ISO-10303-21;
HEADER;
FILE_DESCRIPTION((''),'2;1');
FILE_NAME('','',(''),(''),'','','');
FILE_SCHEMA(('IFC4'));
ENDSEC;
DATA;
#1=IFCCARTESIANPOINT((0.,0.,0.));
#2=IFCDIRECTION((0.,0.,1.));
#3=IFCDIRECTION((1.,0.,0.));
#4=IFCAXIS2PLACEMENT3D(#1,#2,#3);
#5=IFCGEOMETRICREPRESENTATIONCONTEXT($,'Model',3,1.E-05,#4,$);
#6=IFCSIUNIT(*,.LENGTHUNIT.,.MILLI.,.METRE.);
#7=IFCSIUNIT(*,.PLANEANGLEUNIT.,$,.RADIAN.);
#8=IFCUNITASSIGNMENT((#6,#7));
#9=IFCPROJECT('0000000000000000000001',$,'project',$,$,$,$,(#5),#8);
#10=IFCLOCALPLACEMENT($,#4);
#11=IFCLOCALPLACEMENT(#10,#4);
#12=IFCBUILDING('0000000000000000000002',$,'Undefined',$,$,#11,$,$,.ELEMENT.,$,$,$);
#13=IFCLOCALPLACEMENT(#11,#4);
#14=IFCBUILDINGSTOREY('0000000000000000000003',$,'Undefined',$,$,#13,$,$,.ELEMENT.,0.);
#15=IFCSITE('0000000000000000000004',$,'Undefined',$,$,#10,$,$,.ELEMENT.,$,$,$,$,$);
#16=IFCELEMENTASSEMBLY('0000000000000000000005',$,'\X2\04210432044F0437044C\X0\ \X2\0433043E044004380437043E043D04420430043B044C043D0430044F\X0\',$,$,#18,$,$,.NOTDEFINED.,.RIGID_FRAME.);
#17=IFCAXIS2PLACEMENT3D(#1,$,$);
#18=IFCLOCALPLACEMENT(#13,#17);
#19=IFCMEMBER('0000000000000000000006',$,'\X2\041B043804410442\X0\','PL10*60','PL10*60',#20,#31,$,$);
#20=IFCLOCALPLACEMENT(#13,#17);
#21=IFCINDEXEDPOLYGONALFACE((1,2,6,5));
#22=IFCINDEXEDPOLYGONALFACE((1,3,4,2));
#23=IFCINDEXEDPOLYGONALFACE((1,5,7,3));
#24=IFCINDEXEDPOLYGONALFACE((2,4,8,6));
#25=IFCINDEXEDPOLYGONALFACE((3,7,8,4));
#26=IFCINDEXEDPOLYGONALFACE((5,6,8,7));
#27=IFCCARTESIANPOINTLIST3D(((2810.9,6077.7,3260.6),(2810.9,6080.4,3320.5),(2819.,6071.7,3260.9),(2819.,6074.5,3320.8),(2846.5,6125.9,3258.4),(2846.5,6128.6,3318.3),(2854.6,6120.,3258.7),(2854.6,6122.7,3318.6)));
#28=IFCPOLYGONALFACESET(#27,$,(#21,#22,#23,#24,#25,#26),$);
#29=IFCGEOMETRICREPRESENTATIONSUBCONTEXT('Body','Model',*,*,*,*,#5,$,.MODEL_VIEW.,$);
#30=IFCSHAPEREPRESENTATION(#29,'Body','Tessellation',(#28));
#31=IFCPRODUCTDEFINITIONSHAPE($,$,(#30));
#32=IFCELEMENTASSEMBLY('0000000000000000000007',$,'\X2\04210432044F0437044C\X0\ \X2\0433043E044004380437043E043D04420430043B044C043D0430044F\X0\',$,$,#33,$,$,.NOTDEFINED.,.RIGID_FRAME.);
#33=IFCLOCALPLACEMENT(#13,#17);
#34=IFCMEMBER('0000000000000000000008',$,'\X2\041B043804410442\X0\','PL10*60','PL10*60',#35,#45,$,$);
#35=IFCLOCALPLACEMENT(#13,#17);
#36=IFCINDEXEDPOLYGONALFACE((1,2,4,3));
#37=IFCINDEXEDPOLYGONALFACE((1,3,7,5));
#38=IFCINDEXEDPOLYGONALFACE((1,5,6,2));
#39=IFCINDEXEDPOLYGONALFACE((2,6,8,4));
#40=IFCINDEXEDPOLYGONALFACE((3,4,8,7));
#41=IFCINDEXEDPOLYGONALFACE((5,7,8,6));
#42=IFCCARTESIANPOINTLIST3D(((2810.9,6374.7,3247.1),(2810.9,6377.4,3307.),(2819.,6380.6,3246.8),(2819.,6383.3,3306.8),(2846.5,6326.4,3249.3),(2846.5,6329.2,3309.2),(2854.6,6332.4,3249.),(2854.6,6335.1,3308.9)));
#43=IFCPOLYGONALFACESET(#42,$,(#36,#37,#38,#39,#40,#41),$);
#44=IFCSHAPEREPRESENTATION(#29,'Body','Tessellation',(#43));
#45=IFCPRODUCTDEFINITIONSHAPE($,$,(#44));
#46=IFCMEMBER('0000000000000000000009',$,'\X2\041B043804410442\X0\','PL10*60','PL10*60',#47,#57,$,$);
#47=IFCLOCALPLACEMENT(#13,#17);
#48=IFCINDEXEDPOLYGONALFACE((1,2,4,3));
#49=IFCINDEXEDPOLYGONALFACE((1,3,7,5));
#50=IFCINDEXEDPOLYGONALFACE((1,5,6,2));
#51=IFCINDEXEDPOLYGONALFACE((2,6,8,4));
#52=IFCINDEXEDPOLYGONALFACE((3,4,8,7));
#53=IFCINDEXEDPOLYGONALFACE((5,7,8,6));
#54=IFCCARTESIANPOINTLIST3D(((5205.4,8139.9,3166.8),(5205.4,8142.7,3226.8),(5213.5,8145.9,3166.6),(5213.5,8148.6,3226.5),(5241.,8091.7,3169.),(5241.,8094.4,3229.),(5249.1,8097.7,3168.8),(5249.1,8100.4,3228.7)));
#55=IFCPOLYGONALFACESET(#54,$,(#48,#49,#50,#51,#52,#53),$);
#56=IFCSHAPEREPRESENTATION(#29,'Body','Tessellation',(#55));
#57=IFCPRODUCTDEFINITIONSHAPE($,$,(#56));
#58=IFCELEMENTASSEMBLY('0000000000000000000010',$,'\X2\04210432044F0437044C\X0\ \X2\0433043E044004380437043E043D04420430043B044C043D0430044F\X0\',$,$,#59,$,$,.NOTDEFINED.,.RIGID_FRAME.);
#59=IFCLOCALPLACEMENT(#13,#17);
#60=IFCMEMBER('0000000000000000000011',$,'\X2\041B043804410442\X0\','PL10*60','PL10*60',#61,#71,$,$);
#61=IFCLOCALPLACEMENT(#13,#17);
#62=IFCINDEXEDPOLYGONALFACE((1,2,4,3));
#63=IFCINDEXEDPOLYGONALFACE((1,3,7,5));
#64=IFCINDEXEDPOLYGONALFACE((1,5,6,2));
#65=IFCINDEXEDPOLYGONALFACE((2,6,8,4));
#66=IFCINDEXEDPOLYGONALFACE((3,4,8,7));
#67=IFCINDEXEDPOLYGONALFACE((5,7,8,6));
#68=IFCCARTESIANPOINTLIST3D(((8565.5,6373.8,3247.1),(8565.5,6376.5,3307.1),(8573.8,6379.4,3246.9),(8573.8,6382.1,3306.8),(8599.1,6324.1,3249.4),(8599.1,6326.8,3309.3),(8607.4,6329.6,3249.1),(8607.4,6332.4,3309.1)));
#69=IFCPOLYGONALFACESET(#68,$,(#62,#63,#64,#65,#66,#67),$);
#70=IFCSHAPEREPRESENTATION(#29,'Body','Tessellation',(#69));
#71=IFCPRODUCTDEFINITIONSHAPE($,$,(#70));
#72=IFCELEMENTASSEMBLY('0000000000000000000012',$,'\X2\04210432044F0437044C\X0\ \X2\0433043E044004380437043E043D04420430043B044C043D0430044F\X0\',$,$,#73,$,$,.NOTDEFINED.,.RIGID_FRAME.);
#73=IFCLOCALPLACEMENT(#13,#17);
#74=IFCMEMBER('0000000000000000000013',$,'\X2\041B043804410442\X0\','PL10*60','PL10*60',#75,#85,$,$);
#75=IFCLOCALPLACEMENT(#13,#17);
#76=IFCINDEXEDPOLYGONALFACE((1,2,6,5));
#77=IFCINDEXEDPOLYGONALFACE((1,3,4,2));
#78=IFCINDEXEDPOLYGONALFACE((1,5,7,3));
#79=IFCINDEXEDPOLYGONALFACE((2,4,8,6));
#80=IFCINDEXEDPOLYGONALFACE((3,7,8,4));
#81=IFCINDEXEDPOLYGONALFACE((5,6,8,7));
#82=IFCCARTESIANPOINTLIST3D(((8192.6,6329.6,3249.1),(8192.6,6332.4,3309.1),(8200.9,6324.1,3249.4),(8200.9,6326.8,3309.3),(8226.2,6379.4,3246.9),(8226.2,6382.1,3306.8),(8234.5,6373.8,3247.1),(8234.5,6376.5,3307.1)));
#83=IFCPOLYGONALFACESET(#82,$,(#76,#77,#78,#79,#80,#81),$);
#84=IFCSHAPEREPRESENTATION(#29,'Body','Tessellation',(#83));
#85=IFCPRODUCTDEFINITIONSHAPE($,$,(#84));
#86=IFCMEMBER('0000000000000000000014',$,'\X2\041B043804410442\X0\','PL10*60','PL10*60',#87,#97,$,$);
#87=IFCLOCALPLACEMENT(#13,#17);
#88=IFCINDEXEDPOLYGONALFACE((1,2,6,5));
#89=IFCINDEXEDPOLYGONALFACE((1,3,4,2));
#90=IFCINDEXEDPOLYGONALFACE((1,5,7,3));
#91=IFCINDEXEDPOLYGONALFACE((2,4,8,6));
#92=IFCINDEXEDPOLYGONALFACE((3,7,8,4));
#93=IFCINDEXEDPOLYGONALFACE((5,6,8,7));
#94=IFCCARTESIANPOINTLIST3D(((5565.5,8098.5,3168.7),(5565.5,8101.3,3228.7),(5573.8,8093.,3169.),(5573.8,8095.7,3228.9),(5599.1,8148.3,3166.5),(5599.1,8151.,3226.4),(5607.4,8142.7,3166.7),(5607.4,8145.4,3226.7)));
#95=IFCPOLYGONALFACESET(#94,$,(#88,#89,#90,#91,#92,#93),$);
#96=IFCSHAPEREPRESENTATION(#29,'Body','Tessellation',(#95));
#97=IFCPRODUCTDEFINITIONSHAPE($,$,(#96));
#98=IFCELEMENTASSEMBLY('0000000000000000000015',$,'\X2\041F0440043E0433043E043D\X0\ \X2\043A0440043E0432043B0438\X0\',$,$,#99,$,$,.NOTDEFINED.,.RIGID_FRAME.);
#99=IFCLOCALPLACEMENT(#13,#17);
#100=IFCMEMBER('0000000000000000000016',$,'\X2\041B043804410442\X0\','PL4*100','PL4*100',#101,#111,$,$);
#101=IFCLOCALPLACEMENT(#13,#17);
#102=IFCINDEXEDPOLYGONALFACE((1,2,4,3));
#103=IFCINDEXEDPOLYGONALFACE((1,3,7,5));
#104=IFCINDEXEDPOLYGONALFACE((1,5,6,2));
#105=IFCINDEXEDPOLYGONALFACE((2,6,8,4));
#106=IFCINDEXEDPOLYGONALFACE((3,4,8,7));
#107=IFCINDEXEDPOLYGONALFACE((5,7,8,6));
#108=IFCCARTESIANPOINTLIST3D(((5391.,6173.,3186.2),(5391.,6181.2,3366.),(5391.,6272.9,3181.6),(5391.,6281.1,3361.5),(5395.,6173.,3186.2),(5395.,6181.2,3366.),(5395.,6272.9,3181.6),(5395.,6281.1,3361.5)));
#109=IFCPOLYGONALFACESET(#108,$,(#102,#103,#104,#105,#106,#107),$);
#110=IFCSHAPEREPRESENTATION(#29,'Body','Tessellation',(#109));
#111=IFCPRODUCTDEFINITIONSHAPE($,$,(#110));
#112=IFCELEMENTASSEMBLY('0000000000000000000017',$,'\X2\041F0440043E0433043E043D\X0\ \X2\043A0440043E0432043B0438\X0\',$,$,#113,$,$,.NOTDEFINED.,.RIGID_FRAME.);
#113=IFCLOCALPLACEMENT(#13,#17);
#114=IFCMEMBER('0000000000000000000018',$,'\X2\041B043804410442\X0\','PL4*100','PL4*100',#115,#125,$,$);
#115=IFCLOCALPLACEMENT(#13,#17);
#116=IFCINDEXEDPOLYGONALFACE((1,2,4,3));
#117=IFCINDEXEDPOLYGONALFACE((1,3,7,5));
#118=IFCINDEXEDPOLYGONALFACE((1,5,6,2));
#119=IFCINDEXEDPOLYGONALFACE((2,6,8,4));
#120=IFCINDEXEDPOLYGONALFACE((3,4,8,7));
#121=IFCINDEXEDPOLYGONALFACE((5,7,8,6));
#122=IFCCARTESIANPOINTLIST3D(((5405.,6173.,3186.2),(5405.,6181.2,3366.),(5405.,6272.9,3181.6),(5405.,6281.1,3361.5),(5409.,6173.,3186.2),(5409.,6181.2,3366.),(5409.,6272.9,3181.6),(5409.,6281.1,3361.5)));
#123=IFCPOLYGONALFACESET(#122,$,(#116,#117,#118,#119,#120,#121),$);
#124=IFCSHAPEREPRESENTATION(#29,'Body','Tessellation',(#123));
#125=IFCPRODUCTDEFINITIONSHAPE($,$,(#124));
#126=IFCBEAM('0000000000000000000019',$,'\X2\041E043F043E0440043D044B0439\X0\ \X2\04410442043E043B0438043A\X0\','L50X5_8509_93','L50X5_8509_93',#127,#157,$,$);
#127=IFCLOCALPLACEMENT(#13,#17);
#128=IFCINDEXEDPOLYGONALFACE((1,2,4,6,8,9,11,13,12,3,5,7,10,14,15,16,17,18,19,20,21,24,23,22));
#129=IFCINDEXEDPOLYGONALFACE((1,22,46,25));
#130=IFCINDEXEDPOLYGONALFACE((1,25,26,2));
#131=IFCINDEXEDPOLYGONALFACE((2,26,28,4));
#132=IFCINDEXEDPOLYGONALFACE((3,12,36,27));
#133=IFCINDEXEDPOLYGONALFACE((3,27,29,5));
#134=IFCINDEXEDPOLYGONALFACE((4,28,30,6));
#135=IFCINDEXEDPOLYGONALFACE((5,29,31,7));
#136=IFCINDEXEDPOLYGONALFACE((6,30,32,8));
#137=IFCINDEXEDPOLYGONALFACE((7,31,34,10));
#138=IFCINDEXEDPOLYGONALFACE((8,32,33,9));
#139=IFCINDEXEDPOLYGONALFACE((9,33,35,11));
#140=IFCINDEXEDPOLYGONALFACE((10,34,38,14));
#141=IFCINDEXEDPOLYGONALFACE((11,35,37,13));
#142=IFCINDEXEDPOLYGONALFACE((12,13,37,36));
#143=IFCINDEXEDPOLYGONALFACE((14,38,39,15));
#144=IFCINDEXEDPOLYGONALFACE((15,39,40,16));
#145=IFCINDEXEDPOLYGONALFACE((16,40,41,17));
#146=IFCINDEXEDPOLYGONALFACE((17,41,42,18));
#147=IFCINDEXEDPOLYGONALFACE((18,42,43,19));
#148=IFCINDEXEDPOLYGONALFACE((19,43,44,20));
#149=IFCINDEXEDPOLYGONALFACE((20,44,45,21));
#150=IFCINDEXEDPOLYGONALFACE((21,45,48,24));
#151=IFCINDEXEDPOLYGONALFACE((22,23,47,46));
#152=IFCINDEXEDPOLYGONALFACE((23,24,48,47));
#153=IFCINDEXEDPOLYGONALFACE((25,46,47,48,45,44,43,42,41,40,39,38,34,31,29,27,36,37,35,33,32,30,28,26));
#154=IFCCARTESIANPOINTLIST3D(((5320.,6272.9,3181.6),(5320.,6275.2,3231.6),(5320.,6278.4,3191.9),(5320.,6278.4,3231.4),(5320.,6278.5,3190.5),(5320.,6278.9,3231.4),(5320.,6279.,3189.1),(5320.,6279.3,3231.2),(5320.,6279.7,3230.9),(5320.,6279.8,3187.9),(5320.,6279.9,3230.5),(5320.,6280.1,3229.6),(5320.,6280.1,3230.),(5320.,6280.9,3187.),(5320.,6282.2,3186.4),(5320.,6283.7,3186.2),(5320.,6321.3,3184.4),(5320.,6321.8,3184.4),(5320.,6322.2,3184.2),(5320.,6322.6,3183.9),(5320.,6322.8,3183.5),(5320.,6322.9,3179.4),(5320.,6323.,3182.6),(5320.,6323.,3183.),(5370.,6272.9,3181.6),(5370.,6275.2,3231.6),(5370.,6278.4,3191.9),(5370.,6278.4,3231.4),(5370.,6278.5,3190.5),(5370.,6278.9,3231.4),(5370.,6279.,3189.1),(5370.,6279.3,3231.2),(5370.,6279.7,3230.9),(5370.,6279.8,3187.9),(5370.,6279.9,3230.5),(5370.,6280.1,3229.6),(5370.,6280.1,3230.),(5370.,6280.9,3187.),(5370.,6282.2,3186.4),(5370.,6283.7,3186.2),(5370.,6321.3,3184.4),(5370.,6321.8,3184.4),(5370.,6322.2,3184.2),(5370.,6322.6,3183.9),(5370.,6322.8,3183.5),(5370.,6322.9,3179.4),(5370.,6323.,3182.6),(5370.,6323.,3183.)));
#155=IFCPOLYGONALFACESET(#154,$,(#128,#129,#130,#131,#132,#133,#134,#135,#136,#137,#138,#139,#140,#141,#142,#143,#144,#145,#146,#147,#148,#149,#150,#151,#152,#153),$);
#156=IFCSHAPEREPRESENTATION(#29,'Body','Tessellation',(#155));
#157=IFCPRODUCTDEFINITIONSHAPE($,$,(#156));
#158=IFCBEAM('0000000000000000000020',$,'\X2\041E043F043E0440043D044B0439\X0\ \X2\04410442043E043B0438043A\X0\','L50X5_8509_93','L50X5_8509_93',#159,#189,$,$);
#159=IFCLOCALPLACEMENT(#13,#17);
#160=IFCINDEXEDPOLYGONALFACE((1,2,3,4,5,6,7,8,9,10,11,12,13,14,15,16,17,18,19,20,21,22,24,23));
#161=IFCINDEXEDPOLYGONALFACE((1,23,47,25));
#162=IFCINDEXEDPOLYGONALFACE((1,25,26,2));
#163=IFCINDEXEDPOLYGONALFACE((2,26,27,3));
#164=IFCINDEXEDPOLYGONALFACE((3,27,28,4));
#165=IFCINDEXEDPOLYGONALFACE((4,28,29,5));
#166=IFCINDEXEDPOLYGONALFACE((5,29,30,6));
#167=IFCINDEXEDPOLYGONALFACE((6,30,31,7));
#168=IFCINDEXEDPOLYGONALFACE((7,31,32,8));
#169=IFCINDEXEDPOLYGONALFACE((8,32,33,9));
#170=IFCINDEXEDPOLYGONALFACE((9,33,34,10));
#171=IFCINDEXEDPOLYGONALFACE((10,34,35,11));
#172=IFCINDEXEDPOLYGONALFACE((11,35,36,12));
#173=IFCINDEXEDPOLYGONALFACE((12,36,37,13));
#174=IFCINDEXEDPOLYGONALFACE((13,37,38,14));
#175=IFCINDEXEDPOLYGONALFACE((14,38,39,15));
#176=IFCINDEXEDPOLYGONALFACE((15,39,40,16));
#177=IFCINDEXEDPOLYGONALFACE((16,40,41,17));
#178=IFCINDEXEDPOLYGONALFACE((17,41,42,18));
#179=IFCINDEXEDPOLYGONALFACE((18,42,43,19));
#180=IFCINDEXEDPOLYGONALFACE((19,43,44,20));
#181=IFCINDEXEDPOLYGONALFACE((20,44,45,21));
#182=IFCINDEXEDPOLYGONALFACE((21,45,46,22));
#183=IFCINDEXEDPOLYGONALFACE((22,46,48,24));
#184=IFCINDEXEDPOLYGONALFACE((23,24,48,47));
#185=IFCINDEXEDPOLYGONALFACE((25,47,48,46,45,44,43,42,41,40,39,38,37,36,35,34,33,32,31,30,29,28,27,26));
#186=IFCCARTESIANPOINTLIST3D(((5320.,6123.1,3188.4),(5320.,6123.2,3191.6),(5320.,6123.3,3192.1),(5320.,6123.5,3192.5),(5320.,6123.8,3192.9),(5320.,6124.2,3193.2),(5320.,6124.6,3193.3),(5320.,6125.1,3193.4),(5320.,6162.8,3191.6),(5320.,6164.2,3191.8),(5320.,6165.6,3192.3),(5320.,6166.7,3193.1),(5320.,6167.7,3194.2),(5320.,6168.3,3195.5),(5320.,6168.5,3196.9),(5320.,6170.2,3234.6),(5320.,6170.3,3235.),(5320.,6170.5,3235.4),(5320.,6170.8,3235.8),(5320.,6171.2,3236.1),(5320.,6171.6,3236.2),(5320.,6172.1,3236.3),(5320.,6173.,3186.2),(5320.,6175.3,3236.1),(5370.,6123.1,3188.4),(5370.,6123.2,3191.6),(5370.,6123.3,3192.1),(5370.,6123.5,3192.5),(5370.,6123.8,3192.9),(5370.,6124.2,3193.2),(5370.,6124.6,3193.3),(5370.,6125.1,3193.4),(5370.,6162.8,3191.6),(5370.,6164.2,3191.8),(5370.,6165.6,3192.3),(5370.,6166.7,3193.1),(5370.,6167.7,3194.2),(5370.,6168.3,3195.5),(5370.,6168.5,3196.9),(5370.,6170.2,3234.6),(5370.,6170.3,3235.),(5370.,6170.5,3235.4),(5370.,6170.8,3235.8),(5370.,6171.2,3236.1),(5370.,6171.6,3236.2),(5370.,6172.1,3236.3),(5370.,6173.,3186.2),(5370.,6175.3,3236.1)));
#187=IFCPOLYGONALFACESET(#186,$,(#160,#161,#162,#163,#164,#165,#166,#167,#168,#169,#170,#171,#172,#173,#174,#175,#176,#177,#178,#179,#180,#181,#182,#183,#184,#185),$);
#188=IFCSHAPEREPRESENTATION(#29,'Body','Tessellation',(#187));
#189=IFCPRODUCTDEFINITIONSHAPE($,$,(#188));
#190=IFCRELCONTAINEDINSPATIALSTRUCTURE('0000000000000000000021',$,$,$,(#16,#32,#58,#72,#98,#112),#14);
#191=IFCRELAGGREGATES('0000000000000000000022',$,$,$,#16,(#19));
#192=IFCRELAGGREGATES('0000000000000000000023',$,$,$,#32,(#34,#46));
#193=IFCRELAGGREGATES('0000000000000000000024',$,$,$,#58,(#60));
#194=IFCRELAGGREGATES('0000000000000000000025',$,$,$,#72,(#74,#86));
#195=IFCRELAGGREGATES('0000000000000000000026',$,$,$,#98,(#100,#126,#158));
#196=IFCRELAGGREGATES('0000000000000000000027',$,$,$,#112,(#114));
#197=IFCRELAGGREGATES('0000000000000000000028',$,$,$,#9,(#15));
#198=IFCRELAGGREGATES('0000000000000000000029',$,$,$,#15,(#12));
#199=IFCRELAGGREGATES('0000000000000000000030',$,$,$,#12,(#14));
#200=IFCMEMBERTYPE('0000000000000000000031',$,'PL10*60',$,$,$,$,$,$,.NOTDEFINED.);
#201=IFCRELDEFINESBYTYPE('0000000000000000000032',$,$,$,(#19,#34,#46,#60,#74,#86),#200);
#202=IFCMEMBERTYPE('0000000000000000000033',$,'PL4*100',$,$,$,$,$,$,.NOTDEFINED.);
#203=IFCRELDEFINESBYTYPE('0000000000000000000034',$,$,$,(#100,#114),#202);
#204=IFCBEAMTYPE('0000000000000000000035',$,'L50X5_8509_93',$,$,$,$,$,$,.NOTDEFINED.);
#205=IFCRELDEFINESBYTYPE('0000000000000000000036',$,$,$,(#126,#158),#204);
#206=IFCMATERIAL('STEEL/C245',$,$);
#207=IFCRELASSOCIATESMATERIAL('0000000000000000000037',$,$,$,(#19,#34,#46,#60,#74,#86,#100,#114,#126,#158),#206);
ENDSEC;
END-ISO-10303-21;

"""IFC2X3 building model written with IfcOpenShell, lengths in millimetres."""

from ifc_helpers import new_model, si_unit, frame, origin_with_axes, origin_2d_with_axis, place, context, subcontext, project, spatial, rectangle, l_section, extrude, material, type_object, element, aggregate, save


model = new_model("IFC2X3")

# Units and contexts
model_context = context("Model", 3, precision=1e-05, world=origin_with_axes())
body_context = subcontext(model_context, "Body", "Model", "MODEL_VIEW")
ifc_project = project(units=[si_unit("LENGTHUNIT", "METRE", prefix="MILLI"), si_unit("PLANEANGLEUNIT", "RADIAN")], contexts=[model_context])

# Site, building, storey
site_placement = place(None, origin_with_axes())
site = spatial("IfcSite", under=ifc_project, at=site_placement, Name="Undefined", CompositionType="ELEMENT")
building_placement = place(site_placement, origin_with_axes())
building = spatial("IfcBuilding", under=site, at=building_placement, Name="Undefined", CompositionType="ELEMENT")
storey_placement = place(building_placement, origin_with_axes())
storey = spatial("IfcBuildingStorey", under=building, at=storey_placement, Name="Undefined", CompositionType="ELEMENT", Elevation=0.0)

# Element assembly, member
assembly_1_placement = place(storey_placement, origin_with_axes())
assembly_1 = element("IfcElementAssembly", 1, at=assembly_1_placement, inside=storey, Name="Связь горизонтальная", AssemblyPlace="NOTDEFINED", PredefinedType="RIGID_FRAME")
ifc_material_1 = material(Name="STEEL/C245")
member_type_1 = type_object("IfcMemberType", Name="PL10*60", PredefinedType="NOTDEFINED")
member_1_placement = place(assembly_1_placement, frame((2832.7, 6098.8, 3259.6), z_axis=(0.593795, 0.803786, -0.036536), x_axis=(0.0, 0.045408, 0.998969)))
member_1 = element("IfcMember", 2, at=member_1_placement, type_object=member_type_1, material=ifc_material_1, Name="Лист", Description="PL10*60", ObjectType="PL10*60", context=body_context, shape_type="SweptSolid", body=[
    extrude(rectangle(XDim=10.0, YDim=60.0, at=origin_2d_with_axis()), frame((60.0, 0.0, 0.0), z_axis=(-1.0, 0.0, 0.0), x_axis=(0.0, -1.0, 0.0)), (0.0, 0.0, 1.0), 60.0),
])

# Element assembly, members
assembly_2_placement = place(storey_placement, origin_with_axes())
assembly_2 = element("IfcElementAssembly", 3, at=assembly_2_placement, inside=storey, Name="Связь горизонтальная", AssemblyPlace="NOTDEFINED", PredefinedType="RIGID_FRAME")
member_2_placement = place(assembly_2_placement, frame((2832.7, 6353.5, 3248.0), z_axis=(-0.593795, 0.803786, -0.036536), x_axis=(0.0, 0.045408, 0.998969)))
member_2 = element("IfcMember", 4, at=member_2_placement, type_object=member_type_1, material=ifc_material_1, Name="Лист", Description="PL10*60", ObjectType="PL10*60", context=body_context, shape_type="SweptSolid", body=[
    extrude(rectangle(XDim=10.0, YDim=60.0, at=origin_2d_with_axis()), frame((60.0, 0.0, 0.0), z_axis=(-1.0, 0.0, 0.0), x_axis=(0.0, -1.0, 0.0)), (0.0, 0.0, 1.0), 60.0),
])
member_3_placement = place(assembly_2_placement, frame((5227.3, 8118.8, 3167.8), z_axis=(0.593795, -0.803786, 0.036536), x_axis=(0.0, 0.045408, 0.998969)))
member_3 = element("IfcMember", 5, at=member_3_placement, type_object=member_type_1, material=ifc_material_1, Name="Лист", Description="PL10*60", ObjectType="PL10*60", context=body_context, shape_type="SweptSolid", body=[
    extrude(rectangle(XDim=10.0, YDim=60.0, at=origin_2d_with_axis()), frame((60.0, 0.0, 0.0), z_axis=(-1.0, 0.0, 0.0), x_axis=(0.0, -1.0, 0.0)), (0.0, 0.0, 1.0), 60.0),
])

# Element assembly, member
assembly_3_placement = place(storey_placement, origin_with_axes())
assembly_3 = element("IfcElementAssembly", 6, at=assembly_3_placement, inside=storey, Name="Связь горизонтальная", AssemblyPlace="NOTDEFINED", PredefinedType="RIGID_FRAME")
member_4_placement = place(assembly_3_placement, frame((8586.5, 6351.7, 3248.1), z_axis=(-0.558918, 0.828367, -0.037653), x_axis=(0.0, 0.045408, 0.998969)))
member_4 = element("IfcMember", 7, at=member_4_placement, type_object=member_type_1, material=ifc_material_1, Name="Лист", Description="PL10*60", ObjectType="PL10*60", context=body_context, shape_type="SweptSolid", body=[
    extrude(rectangle(XDim=10.0, YDim=60.0, at=origin_2d_with_axis()), frame((60.0, 0.0, 0.0), z_axis=(-1.0, 0.0, 0.0), x_axis=(0.0, -1.0, 0.0)), (0.0, 0.0, 1.0), 60.0),
])

# Element assembly, members
assembly_4_placement = place(storey_placement, origin_with_axes())
assembly_4 = element("IfcElementAssembly", 8, at=assembly_4_placement, inside=storey, Name="Связь горизонтальная", AssemblyPlace="NOTDEFINED", PredefinedType="RIGID_FRAME")
member_5_placement = place(assembly_4_placement, frame((8213.5, 6351.7, 3248.1), z_axis=(-0.558918, -0.828367, 0.037653), x_axis=(0.0, 0.045408, 0.998969)))
member_5 = element("IfcMember", 9, at=member_5_placement, type_object=member_type_1, material=ifc_material_1, Name="Лист", Description="PL10*60", ObjectType="PL10*60", context=body_context, shape_type="SweptSolid", body=[
    extrude(rectangle(XDim=10.0, YDim=60.0, at=origin_2d_with_axis()), frame((60.0, 0.0, 0.0), z_axis=(-1.0, 0.0, 0.0), x_axis=(0.0, -1.0, 0.0)), (0.0, 0.0, 1.0), 60.0),
])
member_6_placement = place(assembly_4_placement, frame((5586.5, 8123.3, 3227.7), z_axis=(-0.558918, -0.828367, 0.037653), x_axis=(0.0, -0.045408, -0.998969)))
member_6 = element("IfcMember", 10, at=member_6_placement, type_object=member_type_1, material=ifc_material_1, Name="Лист", Description="PL10*60", ObjectType="PL10*60", context=body_context, shape_type="SweptSolid", body=[
    extrude(rectangle(XDim=10.0, YDim=60.0, at=origin_2d_with_axis()), frame((60.0, 0.0, 0.0), z_axis=(-1.0, 0.0, 0.0), x_axis=(0.0, -1.0, 0.0)), (0.0, 0.0, 1.0), 60.0),
])

# Element assemblies, members
assembly_5_placement = place(storey_placement, origin_with_axes())
assembly_5 = element("IfcElementAssembly", 11, at=assembly_5_placement, inside=storey, Name="Прогон кровли", AssemblyPlace="NOTDEFINED", PredefinedType="RIGID_FRAME")
member_type_2 = type_object("IfcMemberType", Name="PL4*100", PredefinedType="NOTDEFINED")
member_7_placement = place(assembly_5_placement, frame((5393.0, 6223.0, 3183.9), z_axis=(0.0, 0.998969, -0.045408), x_axis=(0.0, 0.045408, 0.998969)))
member_7 = element("IfcMember", 12, at=member_7_placement, type_object=member_type_2, material=ifc_material_1, Name="Лист", Description="PL4*100", ObjectType="PL4*100", context=body_context, shape_type="SweptSolid", body=[
    extrude(rectangle(XDim=4.0, YDim=100.0, at=origin_2d_with_axis()), frame((180.0, 0.0, 0.0), z_axis=(-1.0, 0.0, 0.0), x_axis=(0.0, -1.0, 0.0)), (0.0, 0.0, 1.0), 180.0),
])
assembly_6_placement = place(storey_placement, origin_with_axes())
assembly_6 = element("IfcElementAssembly", 13, at=assembly_6_placement, inside=storey, Name="Прогон кровли", AssemblyPlace="NOTDEFINED", PredefinedType="RIGID_FRAME")
member_8_placement = place(assembly_6_placement, frame((5407.0, 6223.0, 3183.9), z_axis=(0.0, -0.998969, 0.045408), x_axis=(0.0, 0.045408, 0.998969)))
member_8 = element("IfcMember", 14, at=member_8_placement, type_object=member_type_2, material=ifc_material_1, Name="Лист", Description="PL4*100", ObjectType="PL4*100", context=body_context, shape_type="SweptSolid", body=[
    extrude(rectangle(XDim=4.0, YDim=100.0, at=origin_2d_with_axis()), frame((180.0, 0.0, 0.0), z_axis=(-1.0, 0.0, 0.0), x_axis=(0.0, -1.0, 0.0)), (0.0, 0.0, 1.0), 180.0),
])

# Beams
beam_type_1 = type_object("IfcBeamType", Name="L50X5_8509_93", PredefinedType="NOTDEFINED")
beam_1_placement = place(assembly_5_placement, frame((5320.0, 6299.0, 3205.5), z_axis=(0.0, 0.998969, -0.045408), x_axis=(1.0, 0.0, 0.0)))
beam_1 = element("IfcBeam", 15, at=beam_1_placement, type_object=beam_type_1, material=ifc_material_1, Name="Опорный столик", Description="L50X5_8509_93", ObjectType="L50X5_8509_93", context=body_context, shape_type="SweptSolid", body=[
    extrude(l_section(Depth=50.0, Width=50.0, Thickness=5.0, FilletRadius=5.5, EdgeRadius=1.8, at=origin_2d_with_axis()), frame((50.0, 0.0, 0.0), z_axis=(-1.0, 0.0, 0.0), x_axis=(0.0, -1.0, 0.0)), (0.0, 0.0, 1.0), 50.0),
])
beam_2_placement = place(assembly_5_placement, frame((5370.0, 6149.2, 3212.3), z_axis=(0.0, -0.998969, 0.045408), x_axis=(-1.0, 0.0, 0.0)))
beam_2 = element("IfcBeam", 16, at=beam_2_placement, type_object=beam_type_1, material=ifc_material_1, Name="Опорный столик", Description="L50X5_8509_93", ObjectType="L50X5_8509_93", context=body_context, shape_type="SweptSolid", body=[
    extrude(l_section(Depth=50.0, Width=50.0, Thickness=5.0, FilletRadius=5.5, EdgeRadius=1.8, at=origin_2d_with_axis()), frame((50.0, 0.0, 0.0), z_axis=(-1.0, 0.0, 0.0), x_axis=(0.0, -1.0, 0.0)), (0.0, 0.0, 1.0), 50.0),
])

aggregate(assembly_1, [member_1])
aggregate(assembly_2, [member_2, member_3])
aggregate(assembly_3, [member_4])
aggregate(assembly_4, [member_5, member_6])
aggregate(assembly_5, [member_7, beam_1, beam_2])
aggregate(assembly_6, [member_8])

save(model, "model.ifc")
